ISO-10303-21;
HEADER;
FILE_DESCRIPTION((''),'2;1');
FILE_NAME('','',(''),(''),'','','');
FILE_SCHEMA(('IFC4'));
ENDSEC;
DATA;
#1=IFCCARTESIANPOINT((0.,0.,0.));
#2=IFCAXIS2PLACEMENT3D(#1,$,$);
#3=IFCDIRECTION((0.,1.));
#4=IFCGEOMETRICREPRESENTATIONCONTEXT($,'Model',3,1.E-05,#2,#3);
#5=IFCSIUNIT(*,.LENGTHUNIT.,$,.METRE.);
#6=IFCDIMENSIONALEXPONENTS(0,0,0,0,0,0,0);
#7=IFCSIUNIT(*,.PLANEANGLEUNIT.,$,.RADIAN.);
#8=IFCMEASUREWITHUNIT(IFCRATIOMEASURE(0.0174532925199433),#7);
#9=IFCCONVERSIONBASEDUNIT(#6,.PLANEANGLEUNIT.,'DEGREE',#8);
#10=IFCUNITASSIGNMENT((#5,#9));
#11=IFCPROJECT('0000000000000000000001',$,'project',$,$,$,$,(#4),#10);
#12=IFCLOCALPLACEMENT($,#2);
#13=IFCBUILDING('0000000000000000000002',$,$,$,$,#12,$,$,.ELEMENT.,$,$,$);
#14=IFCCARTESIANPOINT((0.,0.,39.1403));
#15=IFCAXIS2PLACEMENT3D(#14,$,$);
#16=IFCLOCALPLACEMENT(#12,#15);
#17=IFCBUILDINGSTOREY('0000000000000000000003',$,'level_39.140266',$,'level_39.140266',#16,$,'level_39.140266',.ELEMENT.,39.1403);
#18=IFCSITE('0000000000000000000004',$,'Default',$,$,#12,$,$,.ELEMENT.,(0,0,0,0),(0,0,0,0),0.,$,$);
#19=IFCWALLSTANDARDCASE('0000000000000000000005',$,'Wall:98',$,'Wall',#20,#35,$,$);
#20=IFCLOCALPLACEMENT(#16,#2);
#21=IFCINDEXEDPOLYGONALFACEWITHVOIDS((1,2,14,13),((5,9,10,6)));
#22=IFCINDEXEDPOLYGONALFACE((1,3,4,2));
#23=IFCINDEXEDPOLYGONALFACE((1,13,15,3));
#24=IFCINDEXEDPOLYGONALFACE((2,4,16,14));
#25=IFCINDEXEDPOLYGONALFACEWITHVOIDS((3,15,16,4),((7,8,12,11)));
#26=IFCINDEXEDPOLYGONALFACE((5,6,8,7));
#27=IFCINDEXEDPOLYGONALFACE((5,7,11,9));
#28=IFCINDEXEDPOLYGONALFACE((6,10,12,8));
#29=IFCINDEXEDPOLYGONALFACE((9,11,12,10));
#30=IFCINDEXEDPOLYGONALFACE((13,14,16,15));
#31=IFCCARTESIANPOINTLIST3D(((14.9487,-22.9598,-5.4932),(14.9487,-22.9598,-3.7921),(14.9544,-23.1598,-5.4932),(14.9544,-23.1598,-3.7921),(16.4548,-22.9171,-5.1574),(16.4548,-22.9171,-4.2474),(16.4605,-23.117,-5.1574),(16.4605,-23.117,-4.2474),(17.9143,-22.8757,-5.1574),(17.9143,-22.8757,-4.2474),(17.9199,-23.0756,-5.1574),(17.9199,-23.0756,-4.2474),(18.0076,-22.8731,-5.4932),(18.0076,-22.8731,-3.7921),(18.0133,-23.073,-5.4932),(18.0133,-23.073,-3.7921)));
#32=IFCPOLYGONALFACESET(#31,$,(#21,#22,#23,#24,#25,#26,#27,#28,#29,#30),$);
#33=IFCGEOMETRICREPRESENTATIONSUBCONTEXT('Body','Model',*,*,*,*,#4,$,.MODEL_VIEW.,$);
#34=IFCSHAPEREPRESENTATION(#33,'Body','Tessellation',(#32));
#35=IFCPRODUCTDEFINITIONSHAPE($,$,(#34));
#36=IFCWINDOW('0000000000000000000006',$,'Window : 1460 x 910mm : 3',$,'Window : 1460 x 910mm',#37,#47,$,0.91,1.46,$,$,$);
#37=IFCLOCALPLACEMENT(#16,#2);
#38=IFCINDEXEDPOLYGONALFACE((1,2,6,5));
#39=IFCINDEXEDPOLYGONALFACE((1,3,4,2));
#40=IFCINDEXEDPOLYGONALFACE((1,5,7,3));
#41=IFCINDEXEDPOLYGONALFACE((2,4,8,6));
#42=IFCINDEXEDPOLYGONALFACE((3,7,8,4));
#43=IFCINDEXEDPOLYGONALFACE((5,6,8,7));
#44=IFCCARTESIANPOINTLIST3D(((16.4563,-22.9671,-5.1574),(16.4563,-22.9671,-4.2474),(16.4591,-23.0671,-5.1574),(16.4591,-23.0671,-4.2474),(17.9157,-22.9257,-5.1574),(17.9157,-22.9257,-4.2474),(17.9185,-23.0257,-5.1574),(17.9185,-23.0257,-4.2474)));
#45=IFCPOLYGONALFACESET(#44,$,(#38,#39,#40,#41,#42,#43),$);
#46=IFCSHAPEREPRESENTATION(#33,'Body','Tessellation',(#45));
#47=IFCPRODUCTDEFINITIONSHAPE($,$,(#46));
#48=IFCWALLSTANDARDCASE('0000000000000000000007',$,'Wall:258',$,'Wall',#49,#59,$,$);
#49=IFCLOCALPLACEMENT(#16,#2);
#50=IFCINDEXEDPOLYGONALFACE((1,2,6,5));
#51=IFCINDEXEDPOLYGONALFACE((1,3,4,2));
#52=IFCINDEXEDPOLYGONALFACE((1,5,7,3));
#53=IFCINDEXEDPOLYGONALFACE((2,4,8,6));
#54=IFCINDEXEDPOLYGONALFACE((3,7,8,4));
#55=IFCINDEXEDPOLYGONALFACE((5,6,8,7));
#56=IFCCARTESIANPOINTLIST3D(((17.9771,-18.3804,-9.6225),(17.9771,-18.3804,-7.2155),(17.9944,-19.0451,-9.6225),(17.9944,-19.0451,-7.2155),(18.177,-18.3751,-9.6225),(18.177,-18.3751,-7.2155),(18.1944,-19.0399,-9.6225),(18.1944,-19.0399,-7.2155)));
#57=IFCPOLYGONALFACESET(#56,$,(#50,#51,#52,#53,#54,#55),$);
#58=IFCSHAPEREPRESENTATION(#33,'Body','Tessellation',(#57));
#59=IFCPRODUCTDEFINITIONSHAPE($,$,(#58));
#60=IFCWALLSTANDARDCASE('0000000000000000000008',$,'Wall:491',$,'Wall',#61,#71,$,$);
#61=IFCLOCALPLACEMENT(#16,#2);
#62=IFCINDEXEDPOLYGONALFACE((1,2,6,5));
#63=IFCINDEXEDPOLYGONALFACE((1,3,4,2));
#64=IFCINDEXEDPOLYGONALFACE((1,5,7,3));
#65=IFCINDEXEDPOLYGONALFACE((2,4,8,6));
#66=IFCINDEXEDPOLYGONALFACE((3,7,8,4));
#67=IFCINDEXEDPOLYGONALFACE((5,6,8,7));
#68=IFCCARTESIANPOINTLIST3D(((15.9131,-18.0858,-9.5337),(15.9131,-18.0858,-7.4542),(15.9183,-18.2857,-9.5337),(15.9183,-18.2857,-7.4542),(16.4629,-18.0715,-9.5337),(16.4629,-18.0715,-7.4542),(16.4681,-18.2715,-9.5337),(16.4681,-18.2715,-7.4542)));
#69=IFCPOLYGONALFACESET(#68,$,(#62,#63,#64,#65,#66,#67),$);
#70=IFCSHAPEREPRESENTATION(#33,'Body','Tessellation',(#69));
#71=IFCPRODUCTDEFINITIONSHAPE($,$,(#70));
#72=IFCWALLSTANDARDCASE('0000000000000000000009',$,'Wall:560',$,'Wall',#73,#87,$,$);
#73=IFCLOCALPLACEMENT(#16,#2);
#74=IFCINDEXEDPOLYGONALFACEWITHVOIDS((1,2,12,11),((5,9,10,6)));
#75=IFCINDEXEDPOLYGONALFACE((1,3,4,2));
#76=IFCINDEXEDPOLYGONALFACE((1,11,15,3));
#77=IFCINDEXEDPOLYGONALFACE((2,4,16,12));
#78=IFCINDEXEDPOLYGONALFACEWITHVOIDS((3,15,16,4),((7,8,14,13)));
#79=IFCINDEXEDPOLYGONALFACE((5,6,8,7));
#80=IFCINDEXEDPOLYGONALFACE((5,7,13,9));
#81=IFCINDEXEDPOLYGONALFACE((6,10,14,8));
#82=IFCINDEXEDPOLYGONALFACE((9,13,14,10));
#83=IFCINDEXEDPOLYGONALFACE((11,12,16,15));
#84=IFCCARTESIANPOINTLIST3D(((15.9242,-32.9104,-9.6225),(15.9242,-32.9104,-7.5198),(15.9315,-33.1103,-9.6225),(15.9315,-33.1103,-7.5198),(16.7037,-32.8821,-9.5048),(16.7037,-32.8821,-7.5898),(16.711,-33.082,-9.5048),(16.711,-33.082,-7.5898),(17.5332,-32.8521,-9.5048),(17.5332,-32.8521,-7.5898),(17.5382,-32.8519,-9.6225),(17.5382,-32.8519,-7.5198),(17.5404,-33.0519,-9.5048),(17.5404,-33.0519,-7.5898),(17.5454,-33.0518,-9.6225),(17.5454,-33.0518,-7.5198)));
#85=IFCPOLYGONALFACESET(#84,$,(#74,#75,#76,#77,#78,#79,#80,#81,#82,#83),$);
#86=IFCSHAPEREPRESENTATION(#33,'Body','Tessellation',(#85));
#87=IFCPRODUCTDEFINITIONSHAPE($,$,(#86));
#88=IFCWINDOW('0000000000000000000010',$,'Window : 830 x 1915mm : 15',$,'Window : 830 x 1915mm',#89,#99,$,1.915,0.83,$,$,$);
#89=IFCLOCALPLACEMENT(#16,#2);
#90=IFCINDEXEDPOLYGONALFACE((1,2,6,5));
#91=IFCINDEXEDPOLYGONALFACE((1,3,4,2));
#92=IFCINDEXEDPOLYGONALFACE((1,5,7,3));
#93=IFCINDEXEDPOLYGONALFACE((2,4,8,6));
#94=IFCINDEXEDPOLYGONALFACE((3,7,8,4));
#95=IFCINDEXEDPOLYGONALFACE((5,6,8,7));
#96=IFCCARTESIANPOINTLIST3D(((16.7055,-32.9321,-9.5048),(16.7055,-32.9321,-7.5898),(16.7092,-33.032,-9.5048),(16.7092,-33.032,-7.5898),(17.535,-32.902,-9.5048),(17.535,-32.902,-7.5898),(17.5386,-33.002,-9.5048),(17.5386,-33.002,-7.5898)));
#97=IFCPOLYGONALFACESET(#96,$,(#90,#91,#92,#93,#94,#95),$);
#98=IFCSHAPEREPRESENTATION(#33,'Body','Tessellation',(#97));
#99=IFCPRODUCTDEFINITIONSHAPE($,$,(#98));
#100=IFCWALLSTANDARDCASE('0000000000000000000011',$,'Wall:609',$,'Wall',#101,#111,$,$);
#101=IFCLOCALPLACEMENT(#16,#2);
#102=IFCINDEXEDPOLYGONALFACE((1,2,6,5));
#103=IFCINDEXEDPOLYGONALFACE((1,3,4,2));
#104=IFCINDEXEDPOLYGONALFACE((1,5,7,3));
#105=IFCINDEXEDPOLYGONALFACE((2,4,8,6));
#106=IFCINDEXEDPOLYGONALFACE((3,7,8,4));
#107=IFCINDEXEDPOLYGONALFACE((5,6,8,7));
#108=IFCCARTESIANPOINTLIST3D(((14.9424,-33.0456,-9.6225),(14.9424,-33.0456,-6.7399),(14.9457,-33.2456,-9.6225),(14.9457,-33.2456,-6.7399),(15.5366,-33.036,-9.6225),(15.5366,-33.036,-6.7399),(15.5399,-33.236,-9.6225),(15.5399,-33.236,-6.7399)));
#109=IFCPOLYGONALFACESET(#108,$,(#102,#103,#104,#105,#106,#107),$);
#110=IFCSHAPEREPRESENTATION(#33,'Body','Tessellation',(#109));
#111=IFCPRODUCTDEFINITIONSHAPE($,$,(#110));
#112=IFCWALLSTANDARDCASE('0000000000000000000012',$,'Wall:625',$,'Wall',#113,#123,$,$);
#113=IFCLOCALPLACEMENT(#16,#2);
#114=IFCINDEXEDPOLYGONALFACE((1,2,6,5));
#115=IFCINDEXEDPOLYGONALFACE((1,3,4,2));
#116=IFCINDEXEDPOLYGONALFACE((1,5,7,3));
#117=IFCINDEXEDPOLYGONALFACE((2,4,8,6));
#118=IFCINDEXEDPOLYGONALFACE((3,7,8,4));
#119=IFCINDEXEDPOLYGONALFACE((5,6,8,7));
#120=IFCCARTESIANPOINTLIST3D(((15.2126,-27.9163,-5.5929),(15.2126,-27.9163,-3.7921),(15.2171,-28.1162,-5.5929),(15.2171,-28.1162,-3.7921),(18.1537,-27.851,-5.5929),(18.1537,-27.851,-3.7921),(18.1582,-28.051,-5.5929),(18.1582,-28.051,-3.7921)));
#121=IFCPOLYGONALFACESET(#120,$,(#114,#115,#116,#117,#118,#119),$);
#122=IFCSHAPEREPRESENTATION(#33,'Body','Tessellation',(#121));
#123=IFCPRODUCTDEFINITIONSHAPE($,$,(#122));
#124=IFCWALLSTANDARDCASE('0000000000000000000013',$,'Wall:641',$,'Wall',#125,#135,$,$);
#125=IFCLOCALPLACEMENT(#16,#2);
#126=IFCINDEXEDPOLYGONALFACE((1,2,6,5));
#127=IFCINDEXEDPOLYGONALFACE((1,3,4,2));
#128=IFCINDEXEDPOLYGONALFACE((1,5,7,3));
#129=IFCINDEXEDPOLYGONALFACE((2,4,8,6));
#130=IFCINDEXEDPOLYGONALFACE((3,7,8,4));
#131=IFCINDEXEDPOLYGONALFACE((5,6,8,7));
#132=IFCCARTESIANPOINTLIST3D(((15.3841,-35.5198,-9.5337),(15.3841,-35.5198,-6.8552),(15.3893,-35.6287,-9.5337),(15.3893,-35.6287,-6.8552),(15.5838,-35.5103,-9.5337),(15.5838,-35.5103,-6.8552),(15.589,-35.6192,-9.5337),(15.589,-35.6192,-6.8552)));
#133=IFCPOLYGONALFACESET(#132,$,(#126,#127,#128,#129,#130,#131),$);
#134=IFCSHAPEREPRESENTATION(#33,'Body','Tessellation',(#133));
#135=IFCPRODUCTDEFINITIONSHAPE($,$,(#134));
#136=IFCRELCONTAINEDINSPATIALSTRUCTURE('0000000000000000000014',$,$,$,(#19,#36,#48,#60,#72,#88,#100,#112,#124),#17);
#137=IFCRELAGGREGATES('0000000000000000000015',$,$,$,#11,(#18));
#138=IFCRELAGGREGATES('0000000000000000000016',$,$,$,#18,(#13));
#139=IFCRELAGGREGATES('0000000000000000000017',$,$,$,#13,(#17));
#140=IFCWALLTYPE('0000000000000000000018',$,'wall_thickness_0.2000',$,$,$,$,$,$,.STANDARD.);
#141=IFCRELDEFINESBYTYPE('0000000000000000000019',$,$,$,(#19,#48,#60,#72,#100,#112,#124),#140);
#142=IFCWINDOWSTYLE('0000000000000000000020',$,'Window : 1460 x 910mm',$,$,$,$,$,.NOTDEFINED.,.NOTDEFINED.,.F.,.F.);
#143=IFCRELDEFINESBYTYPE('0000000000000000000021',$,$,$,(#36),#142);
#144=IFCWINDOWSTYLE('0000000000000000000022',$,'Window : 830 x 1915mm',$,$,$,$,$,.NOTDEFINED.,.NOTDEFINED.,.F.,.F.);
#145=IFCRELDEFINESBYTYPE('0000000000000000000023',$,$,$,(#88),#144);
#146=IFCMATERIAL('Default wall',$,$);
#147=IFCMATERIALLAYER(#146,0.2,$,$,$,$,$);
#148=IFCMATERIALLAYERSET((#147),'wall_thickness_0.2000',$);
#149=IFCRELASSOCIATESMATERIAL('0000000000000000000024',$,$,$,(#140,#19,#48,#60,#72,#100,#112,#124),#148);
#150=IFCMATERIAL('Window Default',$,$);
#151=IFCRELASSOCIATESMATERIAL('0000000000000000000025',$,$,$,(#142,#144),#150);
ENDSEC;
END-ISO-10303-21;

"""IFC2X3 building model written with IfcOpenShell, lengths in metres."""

from ifc_helpers import new_model, entity, si_unit, converted_unit, direction, frame, frame_2d, origin, origin_2d_with_axis, place, context, subcontext, project, spatial, polyline, rectangle, outline, extrude, source, transform, mapped, material, layer, layer_set, layer_usage, type_object, type_shapes, element, fill, save


model = new_model("IFC2X3")

# Units and contexts
model_context = context("Model", 3, precision=1e-05, world=origin(), true_north=direction((0.0, 1.0)))
body_context = subcontext(model_context, "Body", "Model", "MODEL_VIEW")
ifc_project = project(units=[si_unit("LENGTHUNIT", "METRE"), converted_unit("PLANEANGLEUNIT", "DEGREE", entity("IfcRatioMeasure", 0.0174532925199433), si_unit("PLANEANGLEUNIT", "RADIAN"), dimensions=[0, 0, 0, 0, 0, 0, 0])], contexts=[model_context])

# Site, building, storey
placement_1 = place(None, origin())
site = spatial("IfcSite", under=ifc_project, at=placement_1, Name="Default", CompositionType="ELEMENT", RefLatitude=(0, 0, 0, 0), RefLongitude=(0, 0, 0, 0), RefElevation=0.0)
building = spatial("IfcBuilding", under=site, at=placement_1, CompositionType="ELEMENT")
storey_placement = place(placement_1, frame((0.0, 0.0, 39.1403)))
storey = spatial("IfcBuildingStorey", under=building, at=storey_placement, Name="level_39.140266", ObjectType="level_39.140266", LongName="level_39.140266", CompositionType="ELEMENT", Elevation=39.1403)

# Wall, opening, window
ifc_material_1 = material(Name="Default wall")
ifc_layer = layer(ifc_material_1, 0.2)
ifc_layer_set = layer_set([ifc_layer], Name="wall_thickness_0.2000")
ifc_layer_usage = layer_usage(ifc_layer_set, "AXIS2", "POSITIVE", -0.1)
wall_type = type_object("IfcWallType", Name="wall_thickness_0.2000", PredefinedType="STANDARD", material=ifc_layer_set)
placement_2 = place(placement_1, frame((0.0, 0.0, 33.6471)))
wall_1_placement = place(placement_2, frame((14.9515, -23.0598, 0.0), z_axis=(0.0, 0.0, 1.0), x_axis=(0.999598, 0.028355, 0.0)))
wall_1 = element("IfcWallStandardCase", 1, at=wall_1_placement, inside=storey, type_object=wall_type, material=ifc_layer_usage, Name="Wall:98", ObjectType="Wall", context=body_context, shape_type="SweptSolid", body=[
    extrude(outline(polyline([(3.0602, -0.1), (3.0602, 0.1), (0.0, 0.1), (0.0, -0.1), (3.0602, -0.1)])), origin(), (0.0, 0.0, 1.0), 1.7011),
])
opening_1_placement = place(wall_1_placement, frame((1.5068, -0.1, 0.3359)))
opening_1 = element("IfcOpeningElement", 2, at=opening_1_placement, cuts=wall_1, ObjectType="Opening", context=body_context, shape_type="SweptSolid", body=[
    extrude(rectangle(XDim=1.46, YDim=0.91, at=frame_2d((0.455, 0.73), x_axis=(0.0, 1.0))), frame((0.0, 0.0, 0.0), z_axis=(0.0, 1.0, 0.0), x_axis=(0.0, 0.0, 1.0)), (0.0, 0.0, 1.0), 0.2),
])
ifc_material_2 = material(Name="Window Default")
window_style_1 = type_object("IfcWindowStyle", Name="Window : 1460 x 910mm", ConstructionType="NOTDEFINED", OperationType="NOTDEFINED", ParameterTakesPrecedence=False, Sizeable=False, material=ifc_material_2)
shared_shape_1 = source(origin(), body_context, "Body", "SweptSolid", [
    extrude(rectangle(XDim=0.1, YDim=1.46, at=origin_2d_with_axis()), frame((0.73, 0.1, 0.0), z_axis=(0.0, 0.0, 1.0), x_axis=(0.0, 1.0, 0.0)), (0.0, 0.0, 1.0), 0.91),
])
type_shapes(window_style_1, [shared_shape_1])
window_1_placement = place(opening_1_placement, origin())
window_1 = element("IfcWindow", 3, at=window_1_placement, inside=storey, type_object=window_style_1, Name="Window : 1460 x 910mm : 3", ObjectType="Window : 1460 x 910mm", OverallHeight=0.91, OverallWidth=1.46, context=body_context, shape_type="MappedRepresentation", body=[
    mapped(shared_shape_1, transform((0.0, 0.0, 0.0), scale=1.0)),
])
fill(opening_1, window_1)

# Walls
placement_3 = place(placement_1, frame((0.0, 0.0, 29.5178)))
wall_2_placement = place(placement_3, frame((18.077, -18.3777, 0.0), z_axis=(0.0, 0.0, 1.0), x_axis=(0.026141, -0.999658, 0.0)))
element("IfcWallStandardCase", 4, at=wall_2_placement, inside=storey, type_object=wall_type, material=ifc_layer_usage, Name="Wall:258", ObjectType="Wall", context=body_context, shape_type="SweptSolid", body=[
    extrude(outline(polyline([(0.665, -0.1), (0.665, 0.1), (0.0, 0.1), (0.0, -0.1), (0.665, -0.1)])), origin(), (0.0, 0.0, 1.0), 2.4071),
])
placement_4 = place(placement_1, frame((0.0, 0.0, 29.6066)))
wall_3_placement = place(placement_4, frame((16.4655, -18.1715, 0.0), z_axis=(0.0, 0.0, 1.0), x_axis=(-0.999663, -0.025961, 0.0)))
element("IfcWallStandardCase", 5, at=wall_3_placement, inside=storey, type_object=wall_type, material=ifc_layer_usage, Name="Wall:491", ObjectType="Wall", context=body_context, shape_type="SweptSolid", body=[
    extrude(outline(polyline([(0.55, -0.1), (0.55, 0.1), (0.0, 0.1), (0.0, -0.1), (0.55, -0.1)])), origin(), (0.0, 0.0, 1.0), 2.0795),
])

# Wall, opening, window
placement_5 = place(placement_1, frame((0.0, 0.0, 29.5178)))
wall_4_placement = place(placement_5, frame((17.5418, -32.9518, 0.0), z_axis=(0.0, 0.0, 1.0), x_axis=(-0.999343, -0.036241, 0.0)))
wall_4 = element("IfcWallStandardCase", 6, at=wall_4_placement, inside=storey, type_object=wall_type, material=ifc_layer_usage, Name="Wall:560", ObjectType="Wall", context=body_context, shape_type="SweptSolid", body=[
    extrude(outline(polyline([(1.615, -0.1), (1.615, 0.1), (0.0, 0.1), (0.0, -0.1), (1.615, -0.1)])), origin(), (0.0, 0.0, 1.0), 2.1027),
])
opening_2_placement = place(wall_4_placement, frame((0.005, -0.1, 0.1177)))
opening_2 = element("IfcOpeningElement", 7, at=opening_2_placement, cuts=wall_4, ObjectType="Opening", context=body_context, shape_type="SweptSolid", body=[
    extrude(rectangle(XDim=0.83, YDim=1.915, at=frame_2d((0.9575, 0.415), x_axis=(0.0, 1.0))), frame((0.0, 0.0, 0.0), z_axis=(0.0, 1.0, 0.0), x_axis=(0.0, 0.0, 1.0)), (0.0, 0.0, 1.0), 0.2),
])
window_style_2 = type_object("IfcWindowStyle", Name="Window : 830 x 1915mm", ConstructionType="NOTDEFINED", OperationType="NOTDEFINED", ParameterTakesPrecedence=False, Sizeable=False, material=ifc_material_2)
shared_shape_2 = source(origin(), body_context, "Body", "SweptSolid", [
    extrude(rectangle(XDim=0.1, YDim=0.83, at=origin_2d_with_axis()), frame((0.415, 0.1, 0.0), z_axis=(0.0, 0.0, 1.0), x_axis=(0.0, 1.0, 0.0)), (0.0, 0.0, 1.0), 1.915),
])
type_shapes(window_style_2, [shared_shape_2])
window_2_placement = place(opening_2_placement, origin())
window_2 = element("IfcWindow", 8, at=window_2_placement, inside=storey, type_object=window_style_2, Name="Window : 830 x 1915mm : 15", ObjectType="Window : 830 x 1915mm", OverallHeight=1.915, OverallWidth=0.83, context=body_context, shape_type="MappedRepresentation", body=[
    mapped(shared_shape_2, transform((0.0, 0.0, 0.0), scale=1.0)),
])
fill(opening_2, window_2)

# Walls
placement_6 = place(placement_1, frame((0.0, 0.0, 29.5178)))
wall_5_placement = place(placement_6, frame((15.5383, -33.136, 0.0), z_axis=(0.0, 0.0, 1.0), x_axis=(-0.999871, -0.016092, 0.0)))
element("IfcWallStandardCase", 9, at=wall_5_placement, inside=storey, type_object=wall_type, material=ifc_layer_usage, Name="Wall:609", ObjectType="Wall", context=body_context, shape_type="SweptSolid", body=[
    extrude(outline(polyline([(0.5943, -0.1), (0.5943, 0.1), (0.0, 0.1), (0.0, -0.1), (0.5943, -0.1)])), origin(), (0.0, 0.0, 1.0), 2.8826),
])
placement_7 = place(placement_1, frame((0.0, 0.0, 33.5474)))
wall_6_placement = place(placement_7, frame((15.2149, -28.0163, 0.0), z_axis=(0.0, 0.0, 1.0), x_axis=(0.999754, 0.022185, 0.0)))
element("IfcWallStandardCase", 10, at=wall_6_placement, inside=storey, type_object=wall_type, material=ifc_layer_usage, Name="Wall:625", ObjectType="Wall", context=body_context, shape_type="SweptSolid", body=[
    extrude(outline(polyline([(2.9418, -0.1), (2.9418, 0.1), (0.0, 0.1), (0.0, -0.1), (2.9418, -0.1)])), origin(), (0.0, 0.0, 1.0), 1.8008),
])
placement_8 = place(placement_1, frame((0.0, 0.0, 29.6066)))
wall_7_placement = place(placement_8, frame((15.484, -35.515, 0.0), z_axis=(0.0, 0.0, 1.0), x_axis=(0.04757, -0.998868, 0.0)))
element("IfcWallStandardCase", 11, at=wall_7_placement, inside=storey, type_object=wall_type, material=ifc_layer_usage, Name="Wall:641", ObjectType="Wall", context=body_context, shape_type="SweptSolid", body=[
    extrude(outline(polyline([(0.1091, -0.1), (0.1091, 0.1), (0.0, 0.1), (0.0, -0.1), (0.1091, -0.1)])), origin(), (0.0, 0.0, 1.0), 2.6784),
])

save(model, "model.ifc")
